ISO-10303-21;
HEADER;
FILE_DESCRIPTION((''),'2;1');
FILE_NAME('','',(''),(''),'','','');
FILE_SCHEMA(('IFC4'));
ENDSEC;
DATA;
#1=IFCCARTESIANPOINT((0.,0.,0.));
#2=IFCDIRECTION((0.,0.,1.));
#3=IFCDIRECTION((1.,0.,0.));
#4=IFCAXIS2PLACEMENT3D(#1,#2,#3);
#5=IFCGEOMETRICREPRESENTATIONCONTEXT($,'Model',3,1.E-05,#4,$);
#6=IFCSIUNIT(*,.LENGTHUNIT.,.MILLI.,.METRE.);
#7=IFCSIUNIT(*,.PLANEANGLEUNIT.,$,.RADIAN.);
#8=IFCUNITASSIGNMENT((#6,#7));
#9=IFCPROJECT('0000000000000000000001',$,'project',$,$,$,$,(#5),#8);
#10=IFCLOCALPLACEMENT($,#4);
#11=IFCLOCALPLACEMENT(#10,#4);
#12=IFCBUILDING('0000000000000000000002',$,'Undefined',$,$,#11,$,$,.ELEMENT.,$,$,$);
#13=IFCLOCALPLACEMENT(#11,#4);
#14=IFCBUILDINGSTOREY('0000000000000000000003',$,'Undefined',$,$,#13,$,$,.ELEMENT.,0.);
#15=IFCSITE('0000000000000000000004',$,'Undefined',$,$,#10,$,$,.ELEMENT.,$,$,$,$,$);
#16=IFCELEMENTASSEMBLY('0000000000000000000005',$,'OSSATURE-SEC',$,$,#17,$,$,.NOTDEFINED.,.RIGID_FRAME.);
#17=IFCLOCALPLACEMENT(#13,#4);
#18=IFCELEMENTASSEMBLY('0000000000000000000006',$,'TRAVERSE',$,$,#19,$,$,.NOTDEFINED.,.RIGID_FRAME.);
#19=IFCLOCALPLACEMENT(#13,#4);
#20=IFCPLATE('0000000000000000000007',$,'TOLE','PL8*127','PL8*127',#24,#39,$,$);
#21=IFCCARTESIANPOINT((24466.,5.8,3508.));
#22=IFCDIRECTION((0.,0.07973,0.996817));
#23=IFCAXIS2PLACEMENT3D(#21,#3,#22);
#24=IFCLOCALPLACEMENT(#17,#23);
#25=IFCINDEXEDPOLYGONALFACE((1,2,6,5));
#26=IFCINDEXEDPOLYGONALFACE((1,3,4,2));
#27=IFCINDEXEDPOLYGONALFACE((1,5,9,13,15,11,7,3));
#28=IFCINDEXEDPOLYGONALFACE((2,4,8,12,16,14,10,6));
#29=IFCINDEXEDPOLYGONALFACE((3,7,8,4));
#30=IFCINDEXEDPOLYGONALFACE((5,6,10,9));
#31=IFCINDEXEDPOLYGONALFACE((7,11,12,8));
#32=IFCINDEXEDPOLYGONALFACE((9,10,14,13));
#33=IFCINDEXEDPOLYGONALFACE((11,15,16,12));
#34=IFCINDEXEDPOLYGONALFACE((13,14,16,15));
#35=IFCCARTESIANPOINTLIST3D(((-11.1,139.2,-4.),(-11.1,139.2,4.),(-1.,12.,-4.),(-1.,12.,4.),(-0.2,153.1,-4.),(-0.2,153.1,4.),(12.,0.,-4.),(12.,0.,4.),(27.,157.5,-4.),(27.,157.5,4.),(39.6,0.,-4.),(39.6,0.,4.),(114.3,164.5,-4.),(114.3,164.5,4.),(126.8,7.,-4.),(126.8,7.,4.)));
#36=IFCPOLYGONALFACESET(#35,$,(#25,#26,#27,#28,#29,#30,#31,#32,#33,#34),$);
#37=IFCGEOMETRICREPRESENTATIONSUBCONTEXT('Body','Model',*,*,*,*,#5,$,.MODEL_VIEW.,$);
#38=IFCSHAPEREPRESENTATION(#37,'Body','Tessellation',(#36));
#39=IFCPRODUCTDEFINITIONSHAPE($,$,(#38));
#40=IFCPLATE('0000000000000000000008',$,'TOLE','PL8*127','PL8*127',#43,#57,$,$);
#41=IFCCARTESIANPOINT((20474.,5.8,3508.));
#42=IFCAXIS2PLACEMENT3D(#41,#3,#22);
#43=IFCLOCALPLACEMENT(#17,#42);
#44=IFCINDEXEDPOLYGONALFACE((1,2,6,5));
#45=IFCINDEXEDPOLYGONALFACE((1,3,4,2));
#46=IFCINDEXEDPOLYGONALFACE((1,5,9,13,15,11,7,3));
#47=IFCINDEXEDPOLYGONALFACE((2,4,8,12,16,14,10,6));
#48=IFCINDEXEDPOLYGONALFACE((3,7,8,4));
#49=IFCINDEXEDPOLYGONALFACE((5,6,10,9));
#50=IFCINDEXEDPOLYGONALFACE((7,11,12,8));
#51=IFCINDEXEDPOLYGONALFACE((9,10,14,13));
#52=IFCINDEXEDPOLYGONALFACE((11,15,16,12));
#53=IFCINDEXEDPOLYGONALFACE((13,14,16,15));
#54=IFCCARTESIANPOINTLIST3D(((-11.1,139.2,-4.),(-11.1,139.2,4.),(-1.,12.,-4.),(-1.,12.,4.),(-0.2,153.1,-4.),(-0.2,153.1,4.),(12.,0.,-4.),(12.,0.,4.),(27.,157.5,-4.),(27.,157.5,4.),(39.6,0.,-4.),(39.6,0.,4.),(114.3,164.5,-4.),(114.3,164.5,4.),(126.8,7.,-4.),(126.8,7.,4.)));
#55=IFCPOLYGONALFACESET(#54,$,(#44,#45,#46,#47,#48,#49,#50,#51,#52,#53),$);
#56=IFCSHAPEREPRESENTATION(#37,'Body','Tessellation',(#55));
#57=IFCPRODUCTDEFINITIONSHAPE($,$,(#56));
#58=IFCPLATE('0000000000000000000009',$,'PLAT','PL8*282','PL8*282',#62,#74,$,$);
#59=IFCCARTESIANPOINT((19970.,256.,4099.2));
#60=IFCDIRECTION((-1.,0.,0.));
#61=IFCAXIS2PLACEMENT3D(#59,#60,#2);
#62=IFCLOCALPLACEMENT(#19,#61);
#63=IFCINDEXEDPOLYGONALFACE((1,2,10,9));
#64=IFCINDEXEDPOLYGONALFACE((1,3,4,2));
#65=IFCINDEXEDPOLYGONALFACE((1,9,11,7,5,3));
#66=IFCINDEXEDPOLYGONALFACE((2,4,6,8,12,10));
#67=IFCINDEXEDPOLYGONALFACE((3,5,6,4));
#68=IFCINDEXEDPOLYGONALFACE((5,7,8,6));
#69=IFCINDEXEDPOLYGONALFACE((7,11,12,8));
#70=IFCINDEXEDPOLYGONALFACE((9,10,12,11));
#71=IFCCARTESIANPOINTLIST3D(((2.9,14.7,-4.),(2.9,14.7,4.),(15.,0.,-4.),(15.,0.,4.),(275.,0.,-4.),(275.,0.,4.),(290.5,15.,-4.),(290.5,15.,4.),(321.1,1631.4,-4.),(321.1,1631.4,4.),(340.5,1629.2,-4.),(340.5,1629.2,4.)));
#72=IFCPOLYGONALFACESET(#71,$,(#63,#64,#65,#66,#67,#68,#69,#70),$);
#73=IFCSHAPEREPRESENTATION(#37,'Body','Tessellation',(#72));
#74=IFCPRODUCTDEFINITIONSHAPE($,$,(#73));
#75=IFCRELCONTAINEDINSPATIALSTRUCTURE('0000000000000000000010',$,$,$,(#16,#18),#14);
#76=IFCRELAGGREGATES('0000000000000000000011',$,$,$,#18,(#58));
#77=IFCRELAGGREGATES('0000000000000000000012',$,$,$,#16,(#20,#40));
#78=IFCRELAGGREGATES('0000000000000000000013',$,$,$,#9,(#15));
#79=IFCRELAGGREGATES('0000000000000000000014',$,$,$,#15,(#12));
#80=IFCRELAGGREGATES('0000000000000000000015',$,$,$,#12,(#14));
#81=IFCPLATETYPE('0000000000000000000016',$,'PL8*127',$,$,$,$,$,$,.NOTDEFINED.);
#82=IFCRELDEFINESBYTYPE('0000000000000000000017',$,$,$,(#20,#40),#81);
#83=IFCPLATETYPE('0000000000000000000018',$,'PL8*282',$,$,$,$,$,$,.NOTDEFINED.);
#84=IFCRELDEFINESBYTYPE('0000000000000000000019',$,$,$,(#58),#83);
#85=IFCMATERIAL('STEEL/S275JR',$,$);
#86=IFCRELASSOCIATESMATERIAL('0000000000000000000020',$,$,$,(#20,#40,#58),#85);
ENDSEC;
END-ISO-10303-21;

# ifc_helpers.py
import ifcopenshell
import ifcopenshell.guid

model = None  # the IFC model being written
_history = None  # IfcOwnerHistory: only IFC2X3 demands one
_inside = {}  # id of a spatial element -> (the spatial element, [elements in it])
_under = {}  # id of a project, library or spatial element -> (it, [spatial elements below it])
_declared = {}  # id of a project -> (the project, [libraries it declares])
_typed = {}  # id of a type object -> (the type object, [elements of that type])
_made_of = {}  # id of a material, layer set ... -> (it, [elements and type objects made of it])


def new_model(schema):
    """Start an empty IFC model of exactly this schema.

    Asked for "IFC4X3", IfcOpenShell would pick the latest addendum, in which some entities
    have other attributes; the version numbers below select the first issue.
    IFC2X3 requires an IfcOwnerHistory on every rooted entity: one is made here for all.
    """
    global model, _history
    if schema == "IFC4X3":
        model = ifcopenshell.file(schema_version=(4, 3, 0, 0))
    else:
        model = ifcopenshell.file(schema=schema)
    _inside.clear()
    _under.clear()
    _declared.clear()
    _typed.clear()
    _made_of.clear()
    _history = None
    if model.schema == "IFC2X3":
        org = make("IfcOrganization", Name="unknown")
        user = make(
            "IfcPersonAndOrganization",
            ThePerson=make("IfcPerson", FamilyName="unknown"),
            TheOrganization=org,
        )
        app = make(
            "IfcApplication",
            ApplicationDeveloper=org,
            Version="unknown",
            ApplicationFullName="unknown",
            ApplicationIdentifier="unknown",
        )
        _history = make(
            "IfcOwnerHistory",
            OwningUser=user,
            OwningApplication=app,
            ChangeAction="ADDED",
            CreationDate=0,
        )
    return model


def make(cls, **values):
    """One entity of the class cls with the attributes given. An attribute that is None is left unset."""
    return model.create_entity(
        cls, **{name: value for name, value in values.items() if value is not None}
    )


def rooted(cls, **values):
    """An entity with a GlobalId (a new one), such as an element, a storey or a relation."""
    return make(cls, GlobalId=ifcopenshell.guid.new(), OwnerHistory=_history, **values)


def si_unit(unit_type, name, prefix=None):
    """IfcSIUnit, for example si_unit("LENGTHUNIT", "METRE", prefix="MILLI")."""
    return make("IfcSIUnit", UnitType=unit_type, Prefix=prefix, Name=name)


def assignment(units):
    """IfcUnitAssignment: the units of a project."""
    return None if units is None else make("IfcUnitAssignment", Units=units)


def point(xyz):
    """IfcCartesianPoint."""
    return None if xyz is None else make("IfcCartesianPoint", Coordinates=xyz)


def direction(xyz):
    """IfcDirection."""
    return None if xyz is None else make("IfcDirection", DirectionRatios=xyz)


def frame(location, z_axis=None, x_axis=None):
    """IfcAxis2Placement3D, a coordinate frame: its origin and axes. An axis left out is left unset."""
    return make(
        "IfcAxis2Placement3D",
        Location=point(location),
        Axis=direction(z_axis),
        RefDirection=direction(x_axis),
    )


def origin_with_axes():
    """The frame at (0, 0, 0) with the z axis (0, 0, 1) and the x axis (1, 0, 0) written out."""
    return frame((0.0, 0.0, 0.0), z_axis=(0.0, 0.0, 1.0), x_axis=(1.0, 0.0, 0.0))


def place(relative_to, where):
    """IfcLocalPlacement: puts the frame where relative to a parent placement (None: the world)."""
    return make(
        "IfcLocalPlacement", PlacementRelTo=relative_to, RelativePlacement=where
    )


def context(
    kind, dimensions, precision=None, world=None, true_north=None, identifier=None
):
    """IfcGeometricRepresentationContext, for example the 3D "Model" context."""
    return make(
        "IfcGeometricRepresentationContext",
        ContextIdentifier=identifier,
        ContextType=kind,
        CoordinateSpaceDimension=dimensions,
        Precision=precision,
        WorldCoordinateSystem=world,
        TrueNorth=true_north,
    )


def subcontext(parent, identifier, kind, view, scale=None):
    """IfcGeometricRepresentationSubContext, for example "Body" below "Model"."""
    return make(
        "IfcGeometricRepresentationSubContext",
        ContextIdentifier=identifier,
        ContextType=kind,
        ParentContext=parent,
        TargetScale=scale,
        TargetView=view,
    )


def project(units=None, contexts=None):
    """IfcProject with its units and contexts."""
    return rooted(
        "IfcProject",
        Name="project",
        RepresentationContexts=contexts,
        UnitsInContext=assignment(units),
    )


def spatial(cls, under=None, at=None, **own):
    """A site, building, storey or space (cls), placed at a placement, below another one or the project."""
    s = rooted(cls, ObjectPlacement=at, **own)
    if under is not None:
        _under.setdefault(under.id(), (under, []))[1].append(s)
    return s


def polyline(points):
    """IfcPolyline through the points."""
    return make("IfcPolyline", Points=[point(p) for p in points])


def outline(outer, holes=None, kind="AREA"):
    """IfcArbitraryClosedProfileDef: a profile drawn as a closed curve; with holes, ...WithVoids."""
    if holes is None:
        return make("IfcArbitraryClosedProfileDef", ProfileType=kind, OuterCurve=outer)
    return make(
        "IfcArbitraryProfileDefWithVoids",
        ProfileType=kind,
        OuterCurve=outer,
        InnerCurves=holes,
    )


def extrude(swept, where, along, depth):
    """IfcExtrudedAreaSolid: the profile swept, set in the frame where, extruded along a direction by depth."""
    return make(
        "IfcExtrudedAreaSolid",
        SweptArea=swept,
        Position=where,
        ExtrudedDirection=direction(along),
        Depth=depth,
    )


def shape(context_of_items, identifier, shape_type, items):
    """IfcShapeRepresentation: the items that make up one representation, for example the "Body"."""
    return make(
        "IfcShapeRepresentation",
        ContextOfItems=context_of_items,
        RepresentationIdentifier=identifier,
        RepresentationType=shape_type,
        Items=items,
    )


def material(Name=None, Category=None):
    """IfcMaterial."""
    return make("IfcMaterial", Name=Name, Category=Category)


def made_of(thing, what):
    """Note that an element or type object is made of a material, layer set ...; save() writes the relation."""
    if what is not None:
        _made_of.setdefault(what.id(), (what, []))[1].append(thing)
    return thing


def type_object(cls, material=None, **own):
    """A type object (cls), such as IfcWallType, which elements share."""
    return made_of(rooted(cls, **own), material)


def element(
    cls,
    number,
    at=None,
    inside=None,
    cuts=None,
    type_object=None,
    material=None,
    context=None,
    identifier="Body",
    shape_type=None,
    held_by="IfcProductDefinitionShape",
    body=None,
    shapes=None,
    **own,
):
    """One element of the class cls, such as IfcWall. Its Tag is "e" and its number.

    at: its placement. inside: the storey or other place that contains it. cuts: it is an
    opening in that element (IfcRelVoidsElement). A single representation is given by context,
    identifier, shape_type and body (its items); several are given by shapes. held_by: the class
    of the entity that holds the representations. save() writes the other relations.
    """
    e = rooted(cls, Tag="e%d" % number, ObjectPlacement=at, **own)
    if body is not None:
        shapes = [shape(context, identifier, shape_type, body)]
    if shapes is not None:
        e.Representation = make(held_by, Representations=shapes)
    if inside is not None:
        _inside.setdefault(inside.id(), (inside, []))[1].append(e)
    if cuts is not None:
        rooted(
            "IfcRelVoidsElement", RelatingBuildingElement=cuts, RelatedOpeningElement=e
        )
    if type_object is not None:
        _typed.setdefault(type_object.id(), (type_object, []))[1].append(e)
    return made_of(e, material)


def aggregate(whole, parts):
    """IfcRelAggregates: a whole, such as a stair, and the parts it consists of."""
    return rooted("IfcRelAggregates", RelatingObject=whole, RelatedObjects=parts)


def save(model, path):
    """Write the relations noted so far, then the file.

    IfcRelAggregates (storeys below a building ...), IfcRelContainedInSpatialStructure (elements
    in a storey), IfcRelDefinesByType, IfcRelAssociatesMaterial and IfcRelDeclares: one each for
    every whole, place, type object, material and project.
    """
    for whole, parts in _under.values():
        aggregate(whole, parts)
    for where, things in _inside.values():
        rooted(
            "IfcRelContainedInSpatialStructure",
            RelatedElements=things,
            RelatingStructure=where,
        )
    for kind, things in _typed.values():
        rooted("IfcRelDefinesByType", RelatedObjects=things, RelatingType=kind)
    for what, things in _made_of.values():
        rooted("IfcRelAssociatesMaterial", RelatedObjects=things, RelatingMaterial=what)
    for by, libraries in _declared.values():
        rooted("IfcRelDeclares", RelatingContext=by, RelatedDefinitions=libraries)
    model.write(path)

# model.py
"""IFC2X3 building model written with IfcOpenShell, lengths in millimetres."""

from ifc_helpers import new_model, si_unit, frame, origin_with_axes, place, context, subcontext, project, spatial, polyline, outline, extrude, material, type_object, element, aggregate, save


model = new_model("IFC2X3")

# Units and contexts
model_context = context("Model", 3, precision=1e-05, world=origin_with_axes())
body_context = subcontext(model_context, "Body", "Model", "MODEL_VIEW")
ifc_project = project(units=[si_unit("LENGTHUNIT", "METRE", prefix="MILLI"), si_unit("PLANEANGLEUNIT", "RADIAN")], contexts=[model_context])

# Site, building, storey
site_placement = place(None, origin_with_axes())
site = spatial("IfcSite", under=ifc_project, at=site_placement, Name="Undefined", CompositionType="ELEMENT")
building_placement = place(site_placement, origin_with_axes())
building = spatial("IfcBuilding", under=site, at=building_placement, Name="Undefined", CompositionType="ELEMENT")
storey_placement = place(building_placement, origin_with_axes())
storey = spatial("IfcBuildingStorey", under=building, at=storey_placement, Name="Undefined", CompositionType="ELEMENT", Elevation=0.0)

# Shared definitions
ifc_material_1 = material(Name="STEEL/S275JR")

# Element assemblies
assembly_1_placement = place(storey_placement, origin_with_axes())
assembly_1 = element("IfcElementAssembly", 1, at=assembly_1_placement, inside=storey, Name="OSSATURE-SEC", AssemblyPlace="NOTDEFINED", PredefinedType="RIGID_FRAME")
assembly_2_placement = place(storey_placement, origin_with_axes())
assembly_2 = element("IfcElementAssembly", 2, at=assembly_2_placement, inside=storey, Name="TRAVERSE", AssemblyPlace="NOTDEFINED", PredefinedType="RIGID_FRAME")

# Plates
plate_type_1 = type_object("IfcPlateType", Name="PL8*127", PredefinedType="NOTDEFINED")
plate_1_placement = place(assembly_1_placement, frame((24466.0, 5.8, 3508.0), z_axis=(1.0, 0.0, 0.0), x_axis=(0.0, 0.07973, 0.996817)))
plate_1 = element("IfcPlate", 3, at=plate_1_placement, type_object=plate_type_1, material=ifc_material_1, Name="TOLE", Description="PL8*127", ObjectType="PL8*127", context=body_context, shape_type="SweptSolid", body=[
    extrude(outline(polyline([(-1.0, 12.0), (12.0, 0.0), (39.6, 0.0), (126.8, 7.0), (114.3, 164.5), (27.0, 157.5), (-0.2, 153.1), (-11.1, 139.2), (-1.0, 12.0)])), frame((0.0, 0.0, -4.0), z_axis=(0.0, 0.0, 1.0), x_axis=(1.0, 0.0, 0.0)), (0.0, 0.0, 1.0), 8.0),
])
plate_2_placement = place(assembly_1_placement, frame((20474.0, 5.8, 3508.0), z_axis=(1.0, 0.0, 0.0), x_axis=(0.0, 0.07973, 0.996817)))
plate_2 = element("IfcPlate", 4, at=plate_2_placement, type_object=plate_type_1, material=ifc_material_1, Name="TOLE", Description="PL8*127", ObjectType="PL8*127", context=body_context, shape_type="SweptSolid", body=[
    extrude(outline(polyline([(-1.0, 12.0), (12.0, 0.0), (39.6, 0.0), (126.8, 7.0), (114.3, 164.5), (27.0, 157.5), (-0.2, 153.1), (-11.1, 139.2), (-1.0, 12.0)])), frame((0.0, 0.0, -4.0), z_axis=(0.0, 0.0, 1.0), x_axis=(1.0, 0.0, 0.0)), (0.0, 0.0, 1.0), 8.0),
])
plate_type_2 = type_object("IfcPlateType", Name="PL8*282", PredefinedType="NOTDEFINED")
plate_3_placement = place(assembly_2_placement, frame((19970.0, 256.0, 4099.2), z_axis=(-1.0, 0.0, 0.0), x_axis=(0.0, 0.0, 1.0)))
plate_3 = element("IfcPlate", 5, at=plate_3_placement, type_object=plate_type_2, material=ifc_material_1, Name="PLAT", Description="PL8*282", ObjectType="PL8*282", context=body_context, shape_type="SweptSolid", body=[
    extrude(outline(polyline([(2.9, 14.7), (15.0, 0.0), (275.0, 0.0), (290.5, 15.0), (340.5, 1629.2), (321.1, 1631.4), (2.9, 14.7)])), frame((0.0, 0.0, -4.0), z_axis=(0.0, 0.0, 1.0), x_axis=(1.0, 0.0, 0.0)), (0.0, 0.0, 1.0), 8.0),
])
aggregate(assembly_2, [plate_3])

aggregate(assembly_1, [plate_1, plate_2])

save(model, "model.ifc")
